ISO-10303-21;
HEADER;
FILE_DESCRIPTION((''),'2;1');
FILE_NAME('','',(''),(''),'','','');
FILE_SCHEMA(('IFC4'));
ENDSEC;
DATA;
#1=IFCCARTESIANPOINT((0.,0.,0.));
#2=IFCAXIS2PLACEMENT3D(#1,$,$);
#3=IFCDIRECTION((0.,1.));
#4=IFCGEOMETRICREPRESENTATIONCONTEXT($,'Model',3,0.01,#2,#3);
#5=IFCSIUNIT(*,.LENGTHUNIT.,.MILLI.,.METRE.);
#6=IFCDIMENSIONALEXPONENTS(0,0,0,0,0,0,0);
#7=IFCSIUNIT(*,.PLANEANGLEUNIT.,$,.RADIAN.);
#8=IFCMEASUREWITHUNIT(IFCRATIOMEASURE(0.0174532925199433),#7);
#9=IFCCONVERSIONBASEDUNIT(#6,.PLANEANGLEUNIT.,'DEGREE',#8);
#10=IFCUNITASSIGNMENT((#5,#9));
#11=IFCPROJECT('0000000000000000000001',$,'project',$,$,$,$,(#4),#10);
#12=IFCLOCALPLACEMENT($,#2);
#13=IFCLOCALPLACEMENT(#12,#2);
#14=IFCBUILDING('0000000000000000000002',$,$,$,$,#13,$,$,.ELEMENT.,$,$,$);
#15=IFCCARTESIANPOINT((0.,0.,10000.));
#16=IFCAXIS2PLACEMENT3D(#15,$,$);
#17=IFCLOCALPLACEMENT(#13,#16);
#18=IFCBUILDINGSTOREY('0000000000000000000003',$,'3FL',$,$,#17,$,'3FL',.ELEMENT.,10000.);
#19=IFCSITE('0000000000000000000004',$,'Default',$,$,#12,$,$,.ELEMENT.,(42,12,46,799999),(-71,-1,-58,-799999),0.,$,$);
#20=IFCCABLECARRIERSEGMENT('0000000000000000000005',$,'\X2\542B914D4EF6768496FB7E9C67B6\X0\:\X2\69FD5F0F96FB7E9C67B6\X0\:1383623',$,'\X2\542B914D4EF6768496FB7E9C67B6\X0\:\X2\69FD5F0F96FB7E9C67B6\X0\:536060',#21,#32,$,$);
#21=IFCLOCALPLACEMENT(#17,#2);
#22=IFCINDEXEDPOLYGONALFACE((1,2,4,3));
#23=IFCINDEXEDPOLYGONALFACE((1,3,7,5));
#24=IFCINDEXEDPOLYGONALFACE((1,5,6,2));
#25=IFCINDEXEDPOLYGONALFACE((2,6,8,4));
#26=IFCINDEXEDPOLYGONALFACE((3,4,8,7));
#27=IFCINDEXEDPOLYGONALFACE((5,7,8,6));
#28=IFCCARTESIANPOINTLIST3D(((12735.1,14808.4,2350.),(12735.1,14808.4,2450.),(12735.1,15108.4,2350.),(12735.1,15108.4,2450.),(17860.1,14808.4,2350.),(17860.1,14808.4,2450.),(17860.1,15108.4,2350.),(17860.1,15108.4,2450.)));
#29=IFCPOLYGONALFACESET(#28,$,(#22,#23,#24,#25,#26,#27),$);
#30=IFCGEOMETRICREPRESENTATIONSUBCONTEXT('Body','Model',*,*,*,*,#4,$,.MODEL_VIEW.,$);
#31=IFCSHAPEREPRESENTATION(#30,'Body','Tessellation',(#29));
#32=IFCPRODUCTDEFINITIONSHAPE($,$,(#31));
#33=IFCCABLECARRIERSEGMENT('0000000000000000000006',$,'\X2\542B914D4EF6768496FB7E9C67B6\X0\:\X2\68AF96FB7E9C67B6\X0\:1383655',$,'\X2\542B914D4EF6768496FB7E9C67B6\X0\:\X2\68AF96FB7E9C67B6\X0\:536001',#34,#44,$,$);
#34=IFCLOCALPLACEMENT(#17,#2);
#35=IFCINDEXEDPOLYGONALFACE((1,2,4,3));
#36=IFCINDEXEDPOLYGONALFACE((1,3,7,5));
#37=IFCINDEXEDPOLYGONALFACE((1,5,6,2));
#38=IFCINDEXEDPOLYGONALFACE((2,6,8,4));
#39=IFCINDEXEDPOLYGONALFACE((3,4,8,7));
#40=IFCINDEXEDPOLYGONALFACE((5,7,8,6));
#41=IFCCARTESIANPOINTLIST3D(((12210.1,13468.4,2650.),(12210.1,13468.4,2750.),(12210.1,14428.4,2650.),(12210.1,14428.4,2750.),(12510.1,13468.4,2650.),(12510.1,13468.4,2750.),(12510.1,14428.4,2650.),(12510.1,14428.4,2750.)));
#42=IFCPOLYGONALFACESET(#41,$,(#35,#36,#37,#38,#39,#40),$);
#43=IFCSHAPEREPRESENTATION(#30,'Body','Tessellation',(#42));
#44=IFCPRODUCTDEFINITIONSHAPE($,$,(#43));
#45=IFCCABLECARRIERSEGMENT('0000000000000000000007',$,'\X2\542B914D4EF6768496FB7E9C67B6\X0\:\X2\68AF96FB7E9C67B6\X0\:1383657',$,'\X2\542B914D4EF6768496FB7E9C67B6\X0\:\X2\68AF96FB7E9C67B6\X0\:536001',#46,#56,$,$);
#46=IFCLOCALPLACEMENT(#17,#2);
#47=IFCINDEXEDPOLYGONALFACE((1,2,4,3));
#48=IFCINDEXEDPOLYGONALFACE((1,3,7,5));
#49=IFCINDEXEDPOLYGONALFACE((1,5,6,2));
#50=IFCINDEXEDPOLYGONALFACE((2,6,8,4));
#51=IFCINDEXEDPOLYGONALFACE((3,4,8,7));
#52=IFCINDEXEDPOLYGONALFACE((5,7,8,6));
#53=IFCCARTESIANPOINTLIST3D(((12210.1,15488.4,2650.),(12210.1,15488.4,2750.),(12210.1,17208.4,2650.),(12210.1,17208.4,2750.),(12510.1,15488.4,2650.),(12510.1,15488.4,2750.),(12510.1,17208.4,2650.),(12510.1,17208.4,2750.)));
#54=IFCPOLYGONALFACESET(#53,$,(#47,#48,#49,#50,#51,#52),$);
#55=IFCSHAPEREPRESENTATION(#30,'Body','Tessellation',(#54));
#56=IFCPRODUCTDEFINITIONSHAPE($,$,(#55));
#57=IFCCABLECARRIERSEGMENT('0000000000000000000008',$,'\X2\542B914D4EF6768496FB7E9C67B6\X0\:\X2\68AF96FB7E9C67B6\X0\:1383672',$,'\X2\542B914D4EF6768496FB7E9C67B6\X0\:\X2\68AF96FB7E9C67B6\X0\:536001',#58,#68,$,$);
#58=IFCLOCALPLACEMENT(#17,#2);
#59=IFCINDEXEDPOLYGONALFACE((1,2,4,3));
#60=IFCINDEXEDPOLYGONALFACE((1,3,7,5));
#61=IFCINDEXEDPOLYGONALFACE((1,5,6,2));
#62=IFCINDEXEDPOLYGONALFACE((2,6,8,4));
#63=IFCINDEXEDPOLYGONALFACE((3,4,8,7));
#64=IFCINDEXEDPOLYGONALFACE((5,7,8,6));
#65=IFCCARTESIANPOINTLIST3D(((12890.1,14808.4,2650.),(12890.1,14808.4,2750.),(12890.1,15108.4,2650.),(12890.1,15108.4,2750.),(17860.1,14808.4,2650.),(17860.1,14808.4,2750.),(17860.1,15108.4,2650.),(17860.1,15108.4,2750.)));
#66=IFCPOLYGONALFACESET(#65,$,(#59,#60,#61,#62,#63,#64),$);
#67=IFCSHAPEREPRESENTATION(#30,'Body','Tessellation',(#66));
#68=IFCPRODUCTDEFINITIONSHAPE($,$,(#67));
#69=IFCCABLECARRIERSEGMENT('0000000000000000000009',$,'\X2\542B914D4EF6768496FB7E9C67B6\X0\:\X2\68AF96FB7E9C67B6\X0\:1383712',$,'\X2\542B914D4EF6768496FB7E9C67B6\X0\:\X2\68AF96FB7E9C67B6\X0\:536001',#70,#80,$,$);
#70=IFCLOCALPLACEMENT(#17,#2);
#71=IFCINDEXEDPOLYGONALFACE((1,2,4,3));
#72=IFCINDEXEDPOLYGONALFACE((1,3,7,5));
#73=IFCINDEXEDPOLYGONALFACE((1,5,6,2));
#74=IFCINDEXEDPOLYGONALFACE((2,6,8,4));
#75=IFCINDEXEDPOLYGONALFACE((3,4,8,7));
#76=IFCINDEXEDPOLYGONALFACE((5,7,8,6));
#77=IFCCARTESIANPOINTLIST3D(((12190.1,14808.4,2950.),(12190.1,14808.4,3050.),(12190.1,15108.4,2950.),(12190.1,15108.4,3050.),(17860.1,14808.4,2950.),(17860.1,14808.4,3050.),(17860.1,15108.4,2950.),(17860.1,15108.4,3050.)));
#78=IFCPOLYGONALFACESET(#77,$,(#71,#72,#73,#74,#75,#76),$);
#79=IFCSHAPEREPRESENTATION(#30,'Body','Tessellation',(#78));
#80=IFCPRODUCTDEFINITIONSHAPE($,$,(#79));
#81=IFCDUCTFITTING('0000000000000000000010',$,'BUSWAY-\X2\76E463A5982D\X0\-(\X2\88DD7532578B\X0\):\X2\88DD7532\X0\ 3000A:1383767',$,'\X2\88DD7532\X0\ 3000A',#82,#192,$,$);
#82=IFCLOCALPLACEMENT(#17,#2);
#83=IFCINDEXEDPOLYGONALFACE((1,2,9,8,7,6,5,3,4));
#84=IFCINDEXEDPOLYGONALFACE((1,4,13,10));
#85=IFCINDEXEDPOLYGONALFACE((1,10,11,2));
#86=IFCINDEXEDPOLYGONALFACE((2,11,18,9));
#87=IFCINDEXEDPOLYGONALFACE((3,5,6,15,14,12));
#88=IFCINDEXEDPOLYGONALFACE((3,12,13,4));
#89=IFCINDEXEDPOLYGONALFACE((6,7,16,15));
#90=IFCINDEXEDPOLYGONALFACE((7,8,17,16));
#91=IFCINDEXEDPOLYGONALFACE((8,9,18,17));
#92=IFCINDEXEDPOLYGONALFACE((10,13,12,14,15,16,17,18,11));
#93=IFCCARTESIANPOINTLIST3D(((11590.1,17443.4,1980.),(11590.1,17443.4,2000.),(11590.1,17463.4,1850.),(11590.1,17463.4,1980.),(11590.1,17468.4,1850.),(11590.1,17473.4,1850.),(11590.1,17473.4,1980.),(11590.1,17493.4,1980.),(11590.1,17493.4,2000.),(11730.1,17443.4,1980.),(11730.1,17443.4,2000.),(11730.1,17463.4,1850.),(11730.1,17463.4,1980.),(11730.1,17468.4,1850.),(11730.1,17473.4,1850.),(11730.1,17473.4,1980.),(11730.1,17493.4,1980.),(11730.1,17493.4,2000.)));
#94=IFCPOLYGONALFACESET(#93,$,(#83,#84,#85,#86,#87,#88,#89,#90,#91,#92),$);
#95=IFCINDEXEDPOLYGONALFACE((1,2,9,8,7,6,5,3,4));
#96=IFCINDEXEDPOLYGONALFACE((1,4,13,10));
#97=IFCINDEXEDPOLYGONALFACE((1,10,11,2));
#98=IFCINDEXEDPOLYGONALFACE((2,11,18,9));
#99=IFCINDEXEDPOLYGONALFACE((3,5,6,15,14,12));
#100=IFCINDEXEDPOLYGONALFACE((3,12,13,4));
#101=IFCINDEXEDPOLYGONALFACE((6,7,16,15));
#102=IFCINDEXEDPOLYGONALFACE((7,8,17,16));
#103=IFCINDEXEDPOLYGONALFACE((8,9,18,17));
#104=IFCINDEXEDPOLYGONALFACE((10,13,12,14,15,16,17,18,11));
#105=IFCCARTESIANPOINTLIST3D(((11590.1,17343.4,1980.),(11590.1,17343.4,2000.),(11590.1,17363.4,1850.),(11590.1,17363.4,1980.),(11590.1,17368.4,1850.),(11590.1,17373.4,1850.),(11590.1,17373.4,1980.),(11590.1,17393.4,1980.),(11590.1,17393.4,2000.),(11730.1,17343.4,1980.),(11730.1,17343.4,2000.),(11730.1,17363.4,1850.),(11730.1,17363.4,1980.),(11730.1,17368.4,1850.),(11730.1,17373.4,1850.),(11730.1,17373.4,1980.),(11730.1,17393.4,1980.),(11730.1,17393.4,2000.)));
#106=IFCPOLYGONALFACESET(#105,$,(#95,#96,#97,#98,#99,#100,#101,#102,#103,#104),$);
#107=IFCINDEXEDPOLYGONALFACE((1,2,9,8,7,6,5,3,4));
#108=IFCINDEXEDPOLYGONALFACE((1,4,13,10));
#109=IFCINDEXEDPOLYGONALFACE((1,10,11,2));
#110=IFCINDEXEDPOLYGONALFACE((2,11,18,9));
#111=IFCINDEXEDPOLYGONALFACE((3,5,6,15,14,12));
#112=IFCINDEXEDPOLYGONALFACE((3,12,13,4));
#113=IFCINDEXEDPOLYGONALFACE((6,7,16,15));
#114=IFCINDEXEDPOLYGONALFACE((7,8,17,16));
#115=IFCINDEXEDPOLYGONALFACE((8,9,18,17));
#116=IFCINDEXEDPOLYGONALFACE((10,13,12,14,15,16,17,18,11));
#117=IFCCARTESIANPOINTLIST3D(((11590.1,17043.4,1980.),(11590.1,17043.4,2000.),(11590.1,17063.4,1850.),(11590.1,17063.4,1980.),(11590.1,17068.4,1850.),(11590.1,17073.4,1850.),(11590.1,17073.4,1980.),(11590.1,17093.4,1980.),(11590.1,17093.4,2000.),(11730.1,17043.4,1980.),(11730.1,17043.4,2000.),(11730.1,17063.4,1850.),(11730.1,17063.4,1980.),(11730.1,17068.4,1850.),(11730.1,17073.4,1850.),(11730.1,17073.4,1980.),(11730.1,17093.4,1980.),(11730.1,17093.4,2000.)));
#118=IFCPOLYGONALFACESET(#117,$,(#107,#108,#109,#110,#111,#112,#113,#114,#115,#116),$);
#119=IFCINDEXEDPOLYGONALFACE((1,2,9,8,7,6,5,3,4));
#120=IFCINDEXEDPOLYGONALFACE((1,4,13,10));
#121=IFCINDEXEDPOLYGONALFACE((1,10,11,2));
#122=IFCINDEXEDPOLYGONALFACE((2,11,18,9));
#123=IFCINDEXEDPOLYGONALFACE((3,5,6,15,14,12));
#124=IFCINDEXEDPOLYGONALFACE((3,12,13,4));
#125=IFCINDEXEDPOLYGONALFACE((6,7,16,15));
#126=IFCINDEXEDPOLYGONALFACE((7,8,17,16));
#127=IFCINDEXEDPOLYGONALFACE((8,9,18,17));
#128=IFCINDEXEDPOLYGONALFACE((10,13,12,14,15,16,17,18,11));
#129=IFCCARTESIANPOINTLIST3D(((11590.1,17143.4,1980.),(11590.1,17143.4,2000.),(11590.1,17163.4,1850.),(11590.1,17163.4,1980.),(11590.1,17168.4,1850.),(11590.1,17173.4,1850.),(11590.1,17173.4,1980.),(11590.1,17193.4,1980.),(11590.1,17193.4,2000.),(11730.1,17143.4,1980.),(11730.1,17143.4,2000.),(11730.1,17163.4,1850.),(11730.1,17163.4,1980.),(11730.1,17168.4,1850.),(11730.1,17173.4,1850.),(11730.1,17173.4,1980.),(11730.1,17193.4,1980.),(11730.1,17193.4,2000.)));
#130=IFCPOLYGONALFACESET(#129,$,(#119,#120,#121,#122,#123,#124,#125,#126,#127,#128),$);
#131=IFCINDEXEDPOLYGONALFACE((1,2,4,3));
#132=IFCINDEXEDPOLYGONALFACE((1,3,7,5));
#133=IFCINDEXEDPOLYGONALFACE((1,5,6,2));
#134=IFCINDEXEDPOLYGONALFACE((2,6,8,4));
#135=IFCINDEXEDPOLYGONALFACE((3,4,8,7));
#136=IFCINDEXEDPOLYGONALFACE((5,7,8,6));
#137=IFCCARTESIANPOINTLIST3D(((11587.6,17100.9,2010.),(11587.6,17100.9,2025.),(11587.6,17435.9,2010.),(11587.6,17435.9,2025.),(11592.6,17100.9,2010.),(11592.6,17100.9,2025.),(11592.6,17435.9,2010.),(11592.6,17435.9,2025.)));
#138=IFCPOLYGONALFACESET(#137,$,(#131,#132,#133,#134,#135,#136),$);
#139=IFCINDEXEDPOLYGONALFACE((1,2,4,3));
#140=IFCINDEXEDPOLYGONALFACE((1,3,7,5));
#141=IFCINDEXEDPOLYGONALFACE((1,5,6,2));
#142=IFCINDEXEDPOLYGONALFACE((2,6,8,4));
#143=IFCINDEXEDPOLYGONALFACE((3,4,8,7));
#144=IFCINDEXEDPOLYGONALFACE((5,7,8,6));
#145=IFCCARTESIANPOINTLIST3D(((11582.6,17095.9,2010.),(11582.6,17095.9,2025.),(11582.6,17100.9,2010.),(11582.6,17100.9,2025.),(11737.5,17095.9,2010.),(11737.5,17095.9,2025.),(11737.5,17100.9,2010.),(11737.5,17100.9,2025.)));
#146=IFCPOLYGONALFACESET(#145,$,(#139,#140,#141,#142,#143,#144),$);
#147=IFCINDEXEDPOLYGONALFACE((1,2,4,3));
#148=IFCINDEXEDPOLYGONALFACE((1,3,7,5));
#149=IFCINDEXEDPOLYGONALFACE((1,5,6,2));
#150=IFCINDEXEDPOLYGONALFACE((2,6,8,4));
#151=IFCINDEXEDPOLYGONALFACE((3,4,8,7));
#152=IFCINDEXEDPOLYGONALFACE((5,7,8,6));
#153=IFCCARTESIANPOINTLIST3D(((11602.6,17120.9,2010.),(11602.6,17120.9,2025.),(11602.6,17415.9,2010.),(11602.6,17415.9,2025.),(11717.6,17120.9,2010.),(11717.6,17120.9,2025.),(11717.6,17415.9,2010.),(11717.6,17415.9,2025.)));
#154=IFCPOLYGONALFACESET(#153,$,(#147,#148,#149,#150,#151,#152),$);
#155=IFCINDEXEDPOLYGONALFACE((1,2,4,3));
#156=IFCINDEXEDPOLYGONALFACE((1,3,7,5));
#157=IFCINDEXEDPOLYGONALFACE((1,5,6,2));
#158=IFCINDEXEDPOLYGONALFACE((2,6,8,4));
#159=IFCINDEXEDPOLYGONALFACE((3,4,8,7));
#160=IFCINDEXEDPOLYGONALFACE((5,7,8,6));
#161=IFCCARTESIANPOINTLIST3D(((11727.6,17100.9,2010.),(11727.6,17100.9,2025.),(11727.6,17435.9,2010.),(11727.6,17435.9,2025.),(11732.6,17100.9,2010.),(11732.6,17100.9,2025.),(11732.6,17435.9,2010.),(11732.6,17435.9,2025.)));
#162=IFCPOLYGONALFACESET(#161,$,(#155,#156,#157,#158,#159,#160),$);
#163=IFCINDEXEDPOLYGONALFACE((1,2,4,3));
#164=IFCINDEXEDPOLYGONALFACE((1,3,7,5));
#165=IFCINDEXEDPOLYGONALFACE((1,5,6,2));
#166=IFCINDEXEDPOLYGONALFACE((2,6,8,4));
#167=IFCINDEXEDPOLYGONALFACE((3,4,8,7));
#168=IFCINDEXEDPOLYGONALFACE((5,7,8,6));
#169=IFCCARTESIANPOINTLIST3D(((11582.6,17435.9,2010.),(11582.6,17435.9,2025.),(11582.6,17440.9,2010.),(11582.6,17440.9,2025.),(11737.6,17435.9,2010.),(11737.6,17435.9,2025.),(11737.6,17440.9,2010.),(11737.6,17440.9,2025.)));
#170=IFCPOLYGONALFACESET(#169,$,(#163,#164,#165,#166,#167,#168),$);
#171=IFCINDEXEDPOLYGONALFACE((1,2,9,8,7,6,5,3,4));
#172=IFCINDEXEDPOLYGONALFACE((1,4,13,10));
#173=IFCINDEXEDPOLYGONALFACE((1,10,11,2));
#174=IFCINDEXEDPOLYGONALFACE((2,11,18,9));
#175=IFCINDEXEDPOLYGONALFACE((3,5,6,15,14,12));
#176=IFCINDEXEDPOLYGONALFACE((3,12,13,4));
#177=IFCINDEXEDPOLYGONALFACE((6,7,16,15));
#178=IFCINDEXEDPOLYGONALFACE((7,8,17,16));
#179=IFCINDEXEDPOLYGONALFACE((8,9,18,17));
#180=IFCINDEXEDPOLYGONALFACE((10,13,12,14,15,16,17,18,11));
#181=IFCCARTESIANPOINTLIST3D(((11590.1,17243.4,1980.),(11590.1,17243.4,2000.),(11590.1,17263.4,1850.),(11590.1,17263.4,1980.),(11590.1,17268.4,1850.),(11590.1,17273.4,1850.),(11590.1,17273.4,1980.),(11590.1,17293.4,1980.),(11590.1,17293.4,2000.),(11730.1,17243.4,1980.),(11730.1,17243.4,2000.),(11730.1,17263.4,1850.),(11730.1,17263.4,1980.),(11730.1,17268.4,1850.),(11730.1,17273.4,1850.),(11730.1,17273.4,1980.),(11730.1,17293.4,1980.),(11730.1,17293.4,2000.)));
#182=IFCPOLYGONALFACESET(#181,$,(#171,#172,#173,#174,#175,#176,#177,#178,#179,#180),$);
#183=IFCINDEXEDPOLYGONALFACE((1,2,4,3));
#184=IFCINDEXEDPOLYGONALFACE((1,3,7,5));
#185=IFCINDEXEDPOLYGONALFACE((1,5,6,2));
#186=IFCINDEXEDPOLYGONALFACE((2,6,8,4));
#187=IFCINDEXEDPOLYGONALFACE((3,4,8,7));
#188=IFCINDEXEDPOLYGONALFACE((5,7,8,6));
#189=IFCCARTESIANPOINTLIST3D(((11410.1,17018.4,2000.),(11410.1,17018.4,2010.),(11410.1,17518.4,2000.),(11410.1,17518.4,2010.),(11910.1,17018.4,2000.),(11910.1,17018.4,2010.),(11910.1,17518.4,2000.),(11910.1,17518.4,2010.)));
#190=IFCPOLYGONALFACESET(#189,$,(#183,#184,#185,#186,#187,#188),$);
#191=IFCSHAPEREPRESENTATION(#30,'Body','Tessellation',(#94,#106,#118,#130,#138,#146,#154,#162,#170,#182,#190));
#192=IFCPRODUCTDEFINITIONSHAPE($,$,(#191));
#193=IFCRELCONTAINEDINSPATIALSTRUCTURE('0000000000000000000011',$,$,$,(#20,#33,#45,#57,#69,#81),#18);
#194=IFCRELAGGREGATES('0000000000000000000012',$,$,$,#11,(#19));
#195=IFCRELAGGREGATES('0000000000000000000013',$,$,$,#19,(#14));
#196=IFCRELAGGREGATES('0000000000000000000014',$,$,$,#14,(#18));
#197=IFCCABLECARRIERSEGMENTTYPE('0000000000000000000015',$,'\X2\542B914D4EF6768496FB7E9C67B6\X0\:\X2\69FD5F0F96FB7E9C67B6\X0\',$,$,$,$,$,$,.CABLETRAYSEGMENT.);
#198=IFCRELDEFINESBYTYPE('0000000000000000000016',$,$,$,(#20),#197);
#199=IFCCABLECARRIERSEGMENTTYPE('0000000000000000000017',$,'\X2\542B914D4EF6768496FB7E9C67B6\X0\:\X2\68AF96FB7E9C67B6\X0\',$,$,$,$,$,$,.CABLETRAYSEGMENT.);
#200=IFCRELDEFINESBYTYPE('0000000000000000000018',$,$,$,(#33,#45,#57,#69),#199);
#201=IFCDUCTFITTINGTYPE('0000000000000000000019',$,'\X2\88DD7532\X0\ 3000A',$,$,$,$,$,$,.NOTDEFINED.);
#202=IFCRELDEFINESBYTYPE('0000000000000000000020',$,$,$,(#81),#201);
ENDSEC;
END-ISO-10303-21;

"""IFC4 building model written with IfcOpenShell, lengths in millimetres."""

from ifc_helpers import new_model, entity, si_unit, converted_unit, direction, frame, frame_2d, origin, origin_2d_with_axis, place, context, subcontext, project, spatial, polyline, rectangle, outline, extrude, source, transform, mapped, type_object, type_shapes, element, save


model = new_model("IFC4")

# Units and contexts
model_context = context("Model", 3, precision=0.01, world=origin(), true_north=direction((0.0, 1.0)))
body_context = subcontext(model_context, "Body", "Model", "MODEL_VIEW")
ifc_project = project(units=[si_unit("LENGTHUNIT", "METRE", prefix="MILLI"), converted_unit("PLANEANGLEUNIT", "DEGREE", entity("IfcRatioMeasure", 0.0174532925199433), si_unit("PLANEANGLEUNIT", "RADIAN"), dimensions=[0, 0, 0, 0, 0, 0, 0])], contexts=[model_context])

# Site, building, storey
site_placement = place(None, origin())
site = spatial("IfcSite", under=ifc_project, at=site_placement, Name="Default", CompositionType="ELEMENT", RefLatitude=(42, 12, 46, 799999), RefLongitude=(-71, -1, -58, -799999), RefElevation=0.0)
building_placement = place(site_placement, origin())
building = spatial("IfcBuilding", under=site, at=building_placement, CompositionType="ELEMENT")
storey_placement = place(building_placement, frame((0.0, 0.0, 10000.0)))
storey = spatial("IfcBuildingStorey", under=building, at=storey_placement, Name="3FL", LongName="3FL", CompositionType="ELEMENT", Elevation=10000.0)

# Cable carrier segments
cable_carrier_segment_type_1 = type_object("IfcCableCarrierSegmentType", Name="含配件的電纜架:槽式電纜架", PredefinedType="CABLETRAYSEGMENT")
cable_carrier_segment_1_placement = place(storey_placement, frame((12735.1, 14808.4, 2350.0)))
element("IfcCableCarrierSegment", 1, at=cable_carrier_segment_1_placement, inside=storey, type_object=cable_carrier_segment_type_1, Name="含配件的電纜架:槽式電纜架:1383623", ObjectType="含配件的電纜架:槽式電纜架:536060", context=body_context, shape_type="SweptSolid", body=[
    extrude(rectangle(XDim=5125.0, YDim=300.0, at=frame_2d((0.0, 0.0), x_axis=(1.0, 0.0))), frame((2562.5, 150.0, 0.0), z_axis=(0.0, 0.0, 1.0), x_axis=(-1.0, 0.0, 0.0)), (0.0, 0.0, 1.0), 100.0),
])
cable_carrier_segment_type_2 = type_object("IfcCableCarrierSegmentType", Name="含配件的電纜架:梯電纜架", PredefinedType="CABLETRAYSEGMENT")
cable_carrier_segment_2_placement = place(storey_placement, frame((12210.1, 13468.4, 2650.0)))
element("IfcCableCarrierSegment", 2, at=cable_carrier_segment_2_placement, inside=storey, type_object=cable_carrier_segment_type_2, Name="含配件的電纜架:梯電纜架:1383655", ObjectType="含配件的電纜架:梯電纜架:536001", context=body_context, shape_type="SweptSolid", body=[
    extrude(rectangle(XDim=960.0, YDim=300.0, at=frame_2d((0.0, 0.0), x_axis=(1.0, 0.0))), frame((150.0, 480.0, 0.0), z_axis=(0.0, 0.0, 1.0), x_axis=(0.0, 1.0, 0.0)), (0.0, 0.0, 1.0), 100.0),
])
cable_carrier_segment_3_placement = place(storey_placement, frame((12210.1, 15488.4, 2650.0)))
element("IfcCableCarrierSegment", 3, at=cable_carrier_segment_3_placement, inside=storey, type_object=cable_carrier_segment_type_2, Name="含配件的電纜架:梯電纜架:1383657", ObjectType="含配件的電纜架:梯電纜架:536001", context=body_context, shape_type="SweptSolid", body=[
    extrude(rectangle(XDim=1720.0, YDim=300.0, at=frame_2d((0.0, 0.0), x_axis=(1.0, 0.0))), frame((150.0, 860.0, 0.0), z_axis=(0.0, 0.0, 1.0), x_axis=(0.0, 1.0, 0.0)), (0.0, 0.0, 1.0), 100.0),
])
cable_carrier_segment_4_placement = place(storey_placement, frame((12890.1, 14808.4, 2650.0)))
element("IfcCableCarrierSegment", 4, at=cable_carrier_segment_4_placement, inside=storey, type_object=cable_carrier_segment_type_2, Name="含配件的電纜架:梯電纜架:1383672", ObjectType="含配件的電纜架:梯電纜架:536001", context=body_context, shape_type="SweptSolid", body=[
    extrude(rectangle(XDim=4970.0, YDim=300.0, at=frame_2d((0.0, 0.0), x_axis=(1.0, 0.0))), frame((2485.0, 150.0, 0.0), z_axis=(0.0, 0.0, 1.0), x_axis=(-1.0, 0.0, 0.0)), (0.0, 0.0, 1.0), 100.0),
])
cable_carrier_segment_5_placement = place(storey_placement, frame((12190.1, 14808.4, 2950.0)))
element("IfcCableCarrierSegment", 5, at=cable_carrier_segment_5_placement, inside=storey, type_object=cable_carrier_segment_type_2, Name="含配件的電纜架:梯電纜架:1383712", ObjectType="含配件的電纜架:梯電纜架:536001", context=body_context, shape_type="SweptSolid", body=[
    extrude(rectangle(XDim=5670.0, YDim=300.0, at=frame_2d((0.0, 0.0), x_axis=(1.0, 0.0))), frame((2835.0, 150.0, 0.0), z_axis=(0.0, 0.0, 1.0), x_axis=(-1.0, 0.0, 0.0)), (0.0, 0.0, 1.0), 100.0),
])

# Duct fitting
duct_fitting_type_1 = type_object("IfcDuctFittingType", Name="裝甲 3000A", PredefinedType="NOTDEFINED")
shared_shape_1 = source(origin(), body_context, "Body", "SweptSolid", [
    extrude(outline(polyline([(-25.0, -58.9), (25.0, -58.9), (25.0, -38.9), (5.0, -38.9), (5.0, 91.1), (0.0, 91.1), (-5.0, 91.1), (-5.0, -38.9), (-25.0, -38.9), (-25.0, -58.9)])), frame((-200.0, -70.0, -58.9), z_axis=(0.0, 1.0, 0.0), x_axis=(1.0, 0.0, 0.0)), (0.0, 0.0, 1.0), 140.0),
    extrude(outline(polyline([(-25.0, -58.9), (25.0, -58.9), (25.0, -38.9), (5.0, -38.9), (5.0, 91.1), (0.0, 91.1), (-5.0, 91.1), (-5.0, -38.9), (-25.0, -38.9), (-25.0, -58.9)])), frame((-100.0, -70.0, -58.9), z_axis=(0.0, 1.0, 0.0), x_axis=(1.0, 0.0, 0.0)), (0.0, 0.0, 1.0), 140.0),
    extrude(outline(polyline([(-58.9, -25.0), (-38.9, -25.0), (-38.9, -5.0), (91.1, -5.0), (91.1, 0.0), (91.1, 5.0), (-38.9, 5.0), (-38.9, 25.0), (-58.9, 25.0), (-58.9, -25.0)])), frame((200.0, -70.0, -58.9), z_axis=(0.0, 1.0, 0.0), x_axis=(0.0, 0.0, -1.0)), (0.0, 0.0, 1.0), 140.0),
    extrude(outline(polyline([(-58.9, -25.0), (-38.9, -25.0), (-38.9, -5.0), (91.1, -5.0), (91.1, 0.0), (91.1, 5.0), (-38.9, 5.0), (-38.9, 25.0), (-58.9, 25.0), (-58.9, -25.0)])), frame((100.0, -70.0, -58.9), z_axis=(0.0, 1.0, 0.0), x_axis=(0.0, 0.0, -1.0)), (0.0, 0.0, 1.0), 140.0),
    extrude(rectangle(XDim=335.0, YDim=5.0, at=origin_2d_with_axis()), frame((0.0, -70.0, 10.0), z_axis=(0.0, 0.0, 1.0), x_axis=(-1.0, 0.0, 0.0)), (0.0, 0.0, 1.0), 15.0),
    extrude(rectangle(XDim=5.0, YDim=154.9, at=frame_2d((0.0, 0.0), x_axis=(1.0, 0.0))), frame((170.0, -0.1, 10.0), z_axis=(0.0, 0.0, 1.0), x_axis=(-1.0, 0.0, 0.0)), (0.0, 0.0, 1.0), 15.0),
    extrude(rectangle(XDim=295.0, YDim=115.0, at=origin_2d_with_axis()), frame((0.0, 0.0, 10.0), z_axis=(0.0, 0.0, 1.0), x_axis=(-1.0, 0.0, 0.0)), (0.0, 0.0, 1.0), 15.0),
    extrude(rectangle(XDim=335.0, YDim=5.0, at=origin_2d_with_axis()), frame((0.0, 70.0, 10.0), z_axis=(0.0, 0.0, 1.0), x_axis=(-1.0, 0.0, 0.0)), (0.0, 0.0, 1.0), 15.0),
    extrude(rectangle(XDim=5.0, YDim=155.0, at=origin_2d_with_axis()), frame((-170.0, 0.0, 10.0), z_axis=(0.0, 0.0, 1.0), x_axis=(-1.0, 0.0, 0.0)), (0.0, 0.0, 1.0), 15.0),
    extrude(outline(polyline([(-58.9, -25.0), (-38.9, -25.0), (-38.9, -5.0), (91.1, -5.0), (91.1, 0.0), (91.1, 5.0), (-38.9, 5.0), (-38.9, 25.0), (-58.9, 25.0), (-58.9, -25.0)])), frame((0.0, -70.0, -58.9), z_axis=(0.0, 1.0, 0.0), x_axis=(0.0, 0.0, -1.0)), (0.0, 0.0, 1.0), 140.0),
    extrude(rectangle(XDim=500.0, YDim=500.0, at=origin_2d_with_axis()), frame((0.0, 0.0, 0.0), z_axis=(0.0, 0.0, 1.0), x_axis=(0.0, 1.0, 0.0)), (0.0, 0.0, 1.0), 10.0),
])
type_shapes(duct_fitting_type_1, [shared_shape_1])
for number, where, z_axis, x_axis, name in (
    (6, (11660.1, 17268.4, 2000.0), (0.0, 0.0, 1.0), (0.0, -1.0, 0.0), "BUSWAY-盤接頭-(裝甲型):裝甲 3000A:1383767"),
):
    element("IfcDuctFitting", number, at=place(storey_placement, frame(where, z_axis=z_axis, x_axis=x_axis)), inside=storey, type_object=duct_fitting_type_1, Name=name, ObjectType="裝甲 3000A", context=body_context, shape_type="MappedRepresentation", body=[
        mapped(shared_shape_1, transform((0.0, 0.0, 0.0), scale=1.0)),
    ])

save(model, "model.ifc")
